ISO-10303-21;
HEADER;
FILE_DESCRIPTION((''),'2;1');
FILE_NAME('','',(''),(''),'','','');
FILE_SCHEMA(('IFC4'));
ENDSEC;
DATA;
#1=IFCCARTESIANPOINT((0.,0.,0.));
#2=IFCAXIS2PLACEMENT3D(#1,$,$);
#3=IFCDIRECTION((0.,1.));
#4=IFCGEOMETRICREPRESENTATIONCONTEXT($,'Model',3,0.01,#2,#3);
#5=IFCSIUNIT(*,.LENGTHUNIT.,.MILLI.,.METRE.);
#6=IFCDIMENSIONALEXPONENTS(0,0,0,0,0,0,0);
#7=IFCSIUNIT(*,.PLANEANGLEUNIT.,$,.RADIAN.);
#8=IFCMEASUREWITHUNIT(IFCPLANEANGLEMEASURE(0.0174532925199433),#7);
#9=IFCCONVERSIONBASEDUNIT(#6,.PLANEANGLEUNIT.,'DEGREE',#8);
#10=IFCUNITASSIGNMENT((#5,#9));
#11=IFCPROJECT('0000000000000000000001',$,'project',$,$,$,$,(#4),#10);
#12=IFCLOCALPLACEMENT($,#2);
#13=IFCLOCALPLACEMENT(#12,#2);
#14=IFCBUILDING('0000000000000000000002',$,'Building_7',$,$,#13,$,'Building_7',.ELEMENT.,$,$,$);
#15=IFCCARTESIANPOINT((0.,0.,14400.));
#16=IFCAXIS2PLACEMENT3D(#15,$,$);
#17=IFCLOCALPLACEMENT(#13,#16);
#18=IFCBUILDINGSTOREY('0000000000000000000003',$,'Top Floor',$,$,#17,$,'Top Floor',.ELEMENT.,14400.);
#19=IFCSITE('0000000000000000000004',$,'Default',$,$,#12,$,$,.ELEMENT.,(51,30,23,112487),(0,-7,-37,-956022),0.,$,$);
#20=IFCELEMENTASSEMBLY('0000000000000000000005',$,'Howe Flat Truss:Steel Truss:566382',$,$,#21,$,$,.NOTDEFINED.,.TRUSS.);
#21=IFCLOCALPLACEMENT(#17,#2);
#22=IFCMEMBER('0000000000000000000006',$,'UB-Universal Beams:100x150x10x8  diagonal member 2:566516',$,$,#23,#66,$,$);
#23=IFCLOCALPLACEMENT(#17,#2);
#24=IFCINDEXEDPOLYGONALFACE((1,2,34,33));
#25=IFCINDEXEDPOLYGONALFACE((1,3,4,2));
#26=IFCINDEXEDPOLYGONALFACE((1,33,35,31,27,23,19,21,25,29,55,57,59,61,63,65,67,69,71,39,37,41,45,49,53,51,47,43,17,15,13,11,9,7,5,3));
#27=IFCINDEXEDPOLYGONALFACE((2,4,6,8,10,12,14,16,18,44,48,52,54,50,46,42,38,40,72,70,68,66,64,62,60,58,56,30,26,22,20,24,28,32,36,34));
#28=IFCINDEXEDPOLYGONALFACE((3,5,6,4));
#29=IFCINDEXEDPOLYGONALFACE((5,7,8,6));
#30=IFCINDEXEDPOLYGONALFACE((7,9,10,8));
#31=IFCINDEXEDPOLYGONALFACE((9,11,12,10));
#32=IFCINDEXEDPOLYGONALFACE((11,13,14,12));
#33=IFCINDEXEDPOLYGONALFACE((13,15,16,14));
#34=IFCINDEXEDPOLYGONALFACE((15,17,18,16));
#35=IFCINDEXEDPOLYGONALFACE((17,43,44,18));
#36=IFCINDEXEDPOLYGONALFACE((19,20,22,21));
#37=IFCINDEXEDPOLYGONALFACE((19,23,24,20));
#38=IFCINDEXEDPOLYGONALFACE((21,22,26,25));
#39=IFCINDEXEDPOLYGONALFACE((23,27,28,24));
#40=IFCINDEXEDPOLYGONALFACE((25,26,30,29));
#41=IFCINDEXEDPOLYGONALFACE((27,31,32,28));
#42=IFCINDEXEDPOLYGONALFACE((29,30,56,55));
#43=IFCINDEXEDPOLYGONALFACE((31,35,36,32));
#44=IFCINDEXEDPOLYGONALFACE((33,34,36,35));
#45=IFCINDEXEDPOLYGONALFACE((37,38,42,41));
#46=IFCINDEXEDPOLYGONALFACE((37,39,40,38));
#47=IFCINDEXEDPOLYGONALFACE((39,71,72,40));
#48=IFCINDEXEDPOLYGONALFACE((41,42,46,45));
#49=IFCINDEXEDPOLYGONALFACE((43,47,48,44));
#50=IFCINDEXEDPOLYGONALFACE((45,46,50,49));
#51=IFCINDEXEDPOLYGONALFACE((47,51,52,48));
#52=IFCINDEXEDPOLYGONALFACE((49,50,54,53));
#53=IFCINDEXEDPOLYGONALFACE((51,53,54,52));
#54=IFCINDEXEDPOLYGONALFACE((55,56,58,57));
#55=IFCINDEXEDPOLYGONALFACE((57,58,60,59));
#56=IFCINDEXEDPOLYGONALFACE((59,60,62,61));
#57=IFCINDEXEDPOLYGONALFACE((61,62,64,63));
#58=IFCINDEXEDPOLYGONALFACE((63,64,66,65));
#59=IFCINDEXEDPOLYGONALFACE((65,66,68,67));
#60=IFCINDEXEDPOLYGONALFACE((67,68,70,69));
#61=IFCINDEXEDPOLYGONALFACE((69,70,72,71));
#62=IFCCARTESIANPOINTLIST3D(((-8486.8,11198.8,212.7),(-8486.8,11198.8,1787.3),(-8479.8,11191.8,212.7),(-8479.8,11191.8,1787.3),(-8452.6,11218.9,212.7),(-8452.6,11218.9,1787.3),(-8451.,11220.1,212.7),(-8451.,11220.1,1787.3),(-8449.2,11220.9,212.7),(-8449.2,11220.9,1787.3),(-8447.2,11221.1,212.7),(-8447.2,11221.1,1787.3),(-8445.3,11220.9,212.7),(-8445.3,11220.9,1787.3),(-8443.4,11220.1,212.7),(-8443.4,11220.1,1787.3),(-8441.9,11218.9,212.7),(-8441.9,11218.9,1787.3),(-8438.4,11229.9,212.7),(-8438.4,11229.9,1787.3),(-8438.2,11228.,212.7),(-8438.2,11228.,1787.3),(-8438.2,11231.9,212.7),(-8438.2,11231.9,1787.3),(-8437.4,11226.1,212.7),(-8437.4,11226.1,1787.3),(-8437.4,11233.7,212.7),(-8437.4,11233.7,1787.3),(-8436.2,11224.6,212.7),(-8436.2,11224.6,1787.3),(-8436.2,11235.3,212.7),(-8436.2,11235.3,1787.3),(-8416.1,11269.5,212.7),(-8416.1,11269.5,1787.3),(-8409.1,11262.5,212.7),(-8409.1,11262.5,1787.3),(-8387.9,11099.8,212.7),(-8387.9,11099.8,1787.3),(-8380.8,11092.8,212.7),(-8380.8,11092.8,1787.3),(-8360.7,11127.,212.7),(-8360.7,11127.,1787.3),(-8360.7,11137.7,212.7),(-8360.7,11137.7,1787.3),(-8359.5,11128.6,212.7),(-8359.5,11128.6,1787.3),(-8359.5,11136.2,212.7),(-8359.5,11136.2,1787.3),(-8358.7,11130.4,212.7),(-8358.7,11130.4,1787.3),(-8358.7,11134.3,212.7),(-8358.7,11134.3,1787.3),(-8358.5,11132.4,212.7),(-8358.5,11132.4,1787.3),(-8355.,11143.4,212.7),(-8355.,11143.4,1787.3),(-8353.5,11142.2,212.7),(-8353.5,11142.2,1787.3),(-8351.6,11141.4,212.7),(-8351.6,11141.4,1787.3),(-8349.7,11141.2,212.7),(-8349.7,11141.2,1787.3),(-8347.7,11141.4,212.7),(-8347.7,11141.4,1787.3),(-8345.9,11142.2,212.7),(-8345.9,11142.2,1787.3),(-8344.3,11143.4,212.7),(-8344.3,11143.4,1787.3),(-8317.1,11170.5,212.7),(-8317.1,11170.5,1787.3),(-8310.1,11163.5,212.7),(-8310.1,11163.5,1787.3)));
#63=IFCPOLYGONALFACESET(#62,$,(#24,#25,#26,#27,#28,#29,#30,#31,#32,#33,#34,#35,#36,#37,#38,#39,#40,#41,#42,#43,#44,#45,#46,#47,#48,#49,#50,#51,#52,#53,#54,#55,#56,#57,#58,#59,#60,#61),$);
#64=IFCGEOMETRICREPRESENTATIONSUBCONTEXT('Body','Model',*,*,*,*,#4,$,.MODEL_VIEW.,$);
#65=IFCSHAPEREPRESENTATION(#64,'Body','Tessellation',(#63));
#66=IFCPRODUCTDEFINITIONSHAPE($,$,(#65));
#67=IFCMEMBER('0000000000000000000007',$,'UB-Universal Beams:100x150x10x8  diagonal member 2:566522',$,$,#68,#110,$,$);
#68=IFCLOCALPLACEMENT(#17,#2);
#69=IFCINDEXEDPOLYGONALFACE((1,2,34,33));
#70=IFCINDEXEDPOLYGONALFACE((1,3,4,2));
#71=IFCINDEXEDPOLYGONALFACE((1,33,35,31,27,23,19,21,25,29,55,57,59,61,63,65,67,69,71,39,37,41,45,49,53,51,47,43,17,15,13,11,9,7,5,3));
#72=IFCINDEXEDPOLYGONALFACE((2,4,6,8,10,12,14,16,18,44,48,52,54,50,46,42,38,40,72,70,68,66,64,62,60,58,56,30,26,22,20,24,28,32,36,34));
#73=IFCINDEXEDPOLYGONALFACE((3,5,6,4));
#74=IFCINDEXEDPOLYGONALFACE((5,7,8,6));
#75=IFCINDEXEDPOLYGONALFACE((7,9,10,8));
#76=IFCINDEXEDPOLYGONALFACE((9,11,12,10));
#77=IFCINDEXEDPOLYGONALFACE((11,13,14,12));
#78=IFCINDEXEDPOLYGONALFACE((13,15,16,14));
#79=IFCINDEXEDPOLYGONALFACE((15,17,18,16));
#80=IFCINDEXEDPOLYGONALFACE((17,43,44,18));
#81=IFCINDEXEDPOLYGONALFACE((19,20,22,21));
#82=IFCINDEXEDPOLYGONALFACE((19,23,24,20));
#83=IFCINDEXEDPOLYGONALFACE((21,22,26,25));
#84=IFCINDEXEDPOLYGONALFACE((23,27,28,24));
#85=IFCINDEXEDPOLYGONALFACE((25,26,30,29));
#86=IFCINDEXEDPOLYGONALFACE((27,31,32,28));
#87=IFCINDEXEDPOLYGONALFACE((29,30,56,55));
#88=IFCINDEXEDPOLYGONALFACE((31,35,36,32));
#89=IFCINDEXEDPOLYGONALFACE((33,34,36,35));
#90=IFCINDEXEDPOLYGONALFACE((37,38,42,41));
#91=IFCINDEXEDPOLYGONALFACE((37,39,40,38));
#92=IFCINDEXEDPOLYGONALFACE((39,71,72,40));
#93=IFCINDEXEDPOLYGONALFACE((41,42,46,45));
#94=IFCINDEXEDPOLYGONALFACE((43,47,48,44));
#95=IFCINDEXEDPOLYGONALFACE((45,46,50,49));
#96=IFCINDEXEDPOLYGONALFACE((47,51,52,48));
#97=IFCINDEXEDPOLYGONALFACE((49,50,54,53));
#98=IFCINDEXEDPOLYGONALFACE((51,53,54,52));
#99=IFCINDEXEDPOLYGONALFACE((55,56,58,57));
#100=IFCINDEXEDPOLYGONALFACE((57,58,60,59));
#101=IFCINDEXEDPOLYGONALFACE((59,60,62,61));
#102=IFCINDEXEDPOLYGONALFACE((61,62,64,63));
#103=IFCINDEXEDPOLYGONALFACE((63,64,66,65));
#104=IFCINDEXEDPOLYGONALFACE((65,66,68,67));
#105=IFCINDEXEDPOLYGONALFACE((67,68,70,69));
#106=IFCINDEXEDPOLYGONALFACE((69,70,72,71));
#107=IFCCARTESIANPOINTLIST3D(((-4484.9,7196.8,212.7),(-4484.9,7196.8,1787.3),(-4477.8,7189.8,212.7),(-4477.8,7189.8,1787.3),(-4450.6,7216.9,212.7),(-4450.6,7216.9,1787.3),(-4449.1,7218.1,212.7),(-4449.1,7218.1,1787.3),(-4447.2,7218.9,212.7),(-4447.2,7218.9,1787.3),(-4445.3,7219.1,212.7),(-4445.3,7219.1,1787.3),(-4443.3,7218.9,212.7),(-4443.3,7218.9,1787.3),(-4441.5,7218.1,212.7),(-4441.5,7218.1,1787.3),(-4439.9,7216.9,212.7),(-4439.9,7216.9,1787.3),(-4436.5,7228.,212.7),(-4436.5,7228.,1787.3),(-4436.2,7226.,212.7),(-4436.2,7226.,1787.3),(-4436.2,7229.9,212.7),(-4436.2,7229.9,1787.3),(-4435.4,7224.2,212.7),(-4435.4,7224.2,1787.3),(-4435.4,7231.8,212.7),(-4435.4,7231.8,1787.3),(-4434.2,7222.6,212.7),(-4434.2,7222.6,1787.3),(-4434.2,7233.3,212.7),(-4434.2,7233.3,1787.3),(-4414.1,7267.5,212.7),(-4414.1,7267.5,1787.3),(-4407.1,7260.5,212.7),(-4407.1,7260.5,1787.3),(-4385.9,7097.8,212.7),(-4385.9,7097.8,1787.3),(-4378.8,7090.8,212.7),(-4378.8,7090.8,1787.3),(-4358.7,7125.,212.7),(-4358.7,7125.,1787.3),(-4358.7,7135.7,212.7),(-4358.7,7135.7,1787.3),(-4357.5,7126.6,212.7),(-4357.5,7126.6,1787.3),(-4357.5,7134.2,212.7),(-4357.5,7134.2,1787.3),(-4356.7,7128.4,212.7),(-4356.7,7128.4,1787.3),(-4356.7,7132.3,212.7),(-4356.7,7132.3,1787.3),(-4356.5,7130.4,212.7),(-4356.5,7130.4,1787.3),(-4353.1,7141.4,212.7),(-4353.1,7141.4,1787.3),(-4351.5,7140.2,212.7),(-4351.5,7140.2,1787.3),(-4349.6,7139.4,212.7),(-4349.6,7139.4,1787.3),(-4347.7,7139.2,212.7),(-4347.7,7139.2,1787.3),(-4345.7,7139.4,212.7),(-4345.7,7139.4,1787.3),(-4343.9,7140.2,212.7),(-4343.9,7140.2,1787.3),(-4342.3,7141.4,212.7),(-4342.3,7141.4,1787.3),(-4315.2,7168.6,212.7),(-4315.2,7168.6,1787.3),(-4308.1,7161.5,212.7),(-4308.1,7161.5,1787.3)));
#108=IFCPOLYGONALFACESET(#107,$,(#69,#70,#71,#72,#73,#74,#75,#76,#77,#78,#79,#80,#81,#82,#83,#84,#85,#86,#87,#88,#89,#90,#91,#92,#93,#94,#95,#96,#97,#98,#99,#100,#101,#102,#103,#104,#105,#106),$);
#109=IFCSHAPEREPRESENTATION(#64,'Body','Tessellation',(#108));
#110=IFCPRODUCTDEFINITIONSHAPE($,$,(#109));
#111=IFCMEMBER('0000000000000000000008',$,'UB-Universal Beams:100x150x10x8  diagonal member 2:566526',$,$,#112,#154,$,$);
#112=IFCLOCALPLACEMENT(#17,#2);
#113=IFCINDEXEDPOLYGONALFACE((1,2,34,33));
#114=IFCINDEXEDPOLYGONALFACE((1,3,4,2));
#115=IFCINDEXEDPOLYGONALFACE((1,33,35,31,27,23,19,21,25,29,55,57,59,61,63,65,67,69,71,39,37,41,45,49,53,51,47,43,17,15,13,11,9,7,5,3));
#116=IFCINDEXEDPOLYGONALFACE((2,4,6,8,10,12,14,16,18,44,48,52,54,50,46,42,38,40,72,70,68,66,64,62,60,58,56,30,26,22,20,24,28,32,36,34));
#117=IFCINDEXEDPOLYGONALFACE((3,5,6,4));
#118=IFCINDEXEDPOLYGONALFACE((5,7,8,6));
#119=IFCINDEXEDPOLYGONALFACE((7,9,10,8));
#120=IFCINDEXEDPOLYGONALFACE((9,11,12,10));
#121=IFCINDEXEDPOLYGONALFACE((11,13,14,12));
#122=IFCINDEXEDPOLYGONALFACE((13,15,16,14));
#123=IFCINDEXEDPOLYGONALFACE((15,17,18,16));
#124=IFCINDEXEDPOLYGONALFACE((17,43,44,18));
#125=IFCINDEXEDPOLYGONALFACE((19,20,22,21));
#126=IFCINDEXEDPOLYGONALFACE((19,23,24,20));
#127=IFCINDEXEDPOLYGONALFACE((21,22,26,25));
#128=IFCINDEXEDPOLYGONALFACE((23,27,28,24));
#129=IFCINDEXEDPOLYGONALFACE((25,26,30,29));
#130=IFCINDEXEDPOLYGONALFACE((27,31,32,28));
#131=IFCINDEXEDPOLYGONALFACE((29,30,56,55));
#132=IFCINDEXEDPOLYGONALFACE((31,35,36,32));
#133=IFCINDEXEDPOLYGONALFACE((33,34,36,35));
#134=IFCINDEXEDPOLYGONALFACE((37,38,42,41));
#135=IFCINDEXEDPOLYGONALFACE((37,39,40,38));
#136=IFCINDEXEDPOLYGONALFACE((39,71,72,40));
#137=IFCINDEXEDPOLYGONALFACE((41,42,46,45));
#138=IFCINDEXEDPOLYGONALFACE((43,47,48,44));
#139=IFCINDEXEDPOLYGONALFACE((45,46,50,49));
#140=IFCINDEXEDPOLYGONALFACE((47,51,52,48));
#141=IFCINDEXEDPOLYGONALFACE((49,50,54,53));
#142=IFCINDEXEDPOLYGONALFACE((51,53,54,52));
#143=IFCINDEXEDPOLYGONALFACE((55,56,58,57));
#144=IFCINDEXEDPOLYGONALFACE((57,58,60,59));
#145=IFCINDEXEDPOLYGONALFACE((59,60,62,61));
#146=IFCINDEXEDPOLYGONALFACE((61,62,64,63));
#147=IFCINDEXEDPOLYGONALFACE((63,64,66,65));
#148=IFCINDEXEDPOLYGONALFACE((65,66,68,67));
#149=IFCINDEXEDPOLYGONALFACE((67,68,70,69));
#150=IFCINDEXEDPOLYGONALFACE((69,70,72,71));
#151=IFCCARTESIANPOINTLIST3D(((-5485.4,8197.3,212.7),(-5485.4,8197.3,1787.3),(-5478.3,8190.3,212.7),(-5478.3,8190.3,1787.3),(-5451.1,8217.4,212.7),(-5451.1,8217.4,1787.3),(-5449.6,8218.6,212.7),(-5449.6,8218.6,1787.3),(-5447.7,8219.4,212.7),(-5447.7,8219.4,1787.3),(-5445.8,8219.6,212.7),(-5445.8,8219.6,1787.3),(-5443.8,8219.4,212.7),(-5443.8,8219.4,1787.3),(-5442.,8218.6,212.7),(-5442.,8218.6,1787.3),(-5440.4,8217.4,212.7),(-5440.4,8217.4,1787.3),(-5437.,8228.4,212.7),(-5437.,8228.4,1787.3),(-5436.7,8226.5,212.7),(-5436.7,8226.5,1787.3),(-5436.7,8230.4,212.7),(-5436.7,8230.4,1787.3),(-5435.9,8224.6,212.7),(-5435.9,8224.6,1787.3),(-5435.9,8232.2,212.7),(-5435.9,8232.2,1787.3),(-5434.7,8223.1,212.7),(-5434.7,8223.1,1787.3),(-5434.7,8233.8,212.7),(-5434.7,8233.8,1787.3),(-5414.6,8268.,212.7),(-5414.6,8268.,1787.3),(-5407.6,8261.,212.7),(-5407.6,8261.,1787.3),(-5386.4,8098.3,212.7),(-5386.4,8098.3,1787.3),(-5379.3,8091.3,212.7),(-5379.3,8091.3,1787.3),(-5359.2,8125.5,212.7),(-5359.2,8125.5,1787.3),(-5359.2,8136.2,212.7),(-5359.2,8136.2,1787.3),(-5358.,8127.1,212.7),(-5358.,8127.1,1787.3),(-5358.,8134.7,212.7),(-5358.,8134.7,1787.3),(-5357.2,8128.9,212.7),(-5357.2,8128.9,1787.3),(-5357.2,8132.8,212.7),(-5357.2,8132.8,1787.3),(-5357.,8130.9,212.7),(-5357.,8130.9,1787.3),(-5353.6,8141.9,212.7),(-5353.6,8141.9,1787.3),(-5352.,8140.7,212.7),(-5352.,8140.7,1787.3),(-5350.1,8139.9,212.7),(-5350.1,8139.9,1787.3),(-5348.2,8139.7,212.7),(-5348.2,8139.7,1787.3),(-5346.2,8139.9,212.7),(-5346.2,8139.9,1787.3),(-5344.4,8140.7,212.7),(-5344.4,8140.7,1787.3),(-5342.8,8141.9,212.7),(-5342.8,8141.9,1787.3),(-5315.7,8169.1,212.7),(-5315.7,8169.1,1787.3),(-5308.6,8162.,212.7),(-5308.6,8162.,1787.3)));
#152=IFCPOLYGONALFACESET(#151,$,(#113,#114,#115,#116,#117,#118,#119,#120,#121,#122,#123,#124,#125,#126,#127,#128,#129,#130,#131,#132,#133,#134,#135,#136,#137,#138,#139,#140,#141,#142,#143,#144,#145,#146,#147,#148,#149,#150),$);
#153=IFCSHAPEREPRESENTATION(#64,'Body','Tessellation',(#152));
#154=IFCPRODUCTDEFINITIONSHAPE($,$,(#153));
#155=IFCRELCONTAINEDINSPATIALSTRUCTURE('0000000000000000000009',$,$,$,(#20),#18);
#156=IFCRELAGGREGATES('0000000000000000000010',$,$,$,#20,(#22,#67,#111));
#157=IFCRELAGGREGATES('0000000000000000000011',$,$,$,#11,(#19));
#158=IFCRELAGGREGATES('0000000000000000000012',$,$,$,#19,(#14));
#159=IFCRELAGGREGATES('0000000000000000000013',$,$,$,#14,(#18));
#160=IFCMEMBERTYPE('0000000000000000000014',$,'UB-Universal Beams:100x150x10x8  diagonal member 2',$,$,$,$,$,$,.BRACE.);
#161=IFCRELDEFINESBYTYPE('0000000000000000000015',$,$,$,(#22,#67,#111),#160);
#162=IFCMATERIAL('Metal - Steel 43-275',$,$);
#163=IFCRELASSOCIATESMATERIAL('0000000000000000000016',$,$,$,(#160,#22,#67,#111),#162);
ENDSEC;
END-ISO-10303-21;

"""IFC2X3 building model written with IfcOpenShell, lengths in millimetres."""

from ifc_helpers import new_model, entity, si_unit, converted_unit, direction, frame, frame_2d, origin, place, context, subcontext, project, spatial, polyline, circle_curve, parameter, trimmed, segment, composite_curve, outline, extrude, source, transform, mapped, material, type_object, type_shapes, element, aggregate, save


model = new_model("IFC2X3")

# Units and contexts
model_context = context("Model", 3, precision=0.01, world=origin(), true_north=direction((0.0, 1.0)))
body_context = subcontext(model_context, "Body", "Model", "MODEL_VIEW")
ifc_project = project(units=[si_unit("LENGTHUNIT", "METRE", prefix="MILLI"), converted_unit("PLANEANGLEUNIT", "DEGREE", entity("IfcPlaneAngleMeasure", 0.0174532925199433), si_unit("PLANEANGLEUNIT", "RADIAN"), dimensions=[0, 0, 0, 0, 0, 0, 0])], contexts=[model_context])

# Site, building, storey
site_placement = place(None, origin())
site = spatial("IfcSite", under=ifc_project, at=site_placement, Name="Default", CompositionType="ELEMENT", RefLatitude=(51, 30, 23, 112487), RefLongitude=(0, -7, -37, -956022), RefElevation=0.0)
building_placement = place(site_placement, origin())
building = spatial("IfcBuilding", under=site, at=building_placement, Name="Building_7", LongName="Building_7", CompositionType="ELEMENT")
storey_placement = place(building_placement, frame((0.0, 0.0, 14400.0)))
storey = spatial("IfcBuildingStorey", under=building, at=storey_placement, Name="Top Floor", LongName="Top Floor", CompositionType="ELEMENT", Elevation=14400.0)

# Shared definitions
ifc_material = material(Name="Metal - Steel 43-275")

# Shared definitions
member_type_1 = type_object("IfcMemberType", Name="UB-Universal Beams:100x150x10x8  diagonal member 2", PredefinedType="BRACE", material=ifc_material)
shared_shape_1 = source(origin(), body_context, "Body", "SweptSolid", [
    extrude(outline(composite_curve([segment(polyline([(-50.0, -65.0), (-50.0, -75.0)]), True, "CONTINUOUS"), segment(polyline([(-50.0, -75.0), (50.0, -75.0)]), True, "CONTINUOUS"), segment(polyline([(50.0, -75.0), (50.0, -65.0)]), True, "CONTINUOUS"), segment(polyline([(50.0, -65.0), (11.6, -65.0)]), True, "CONTINUOUS"), segment(trimmed(circle_curve(frame_2d((11.6, -57.4), x_axis=(1.0, 0.0)), 7.6), [parameter(180.0)], [parameter(270.0)], True, "PARAMETER"), False, "CONTINUOUS"), segment(polyline([(4.0, -57.4), (4.0, 57.4)]), True, "CONTINUOUS"), segment(trimmed(circle_curve(frame_2d((11.6, 57.4), x_axis=(1.0, 0.0)), 7.6), [parameter(90.0)], [parameter(180.0)], True, "PARAMETER"), False, "CONTINUOUS"), segment(polyline([(11.6, 65.0), (50.0, 65.0)]), True, "CONTINUOUS"), segment(polyline([(50.0, 65.0), (50.0, 75.0)]), True, "CONTINUOUS"), segment(polyline([(50.0, 75.0), (-50.0, 75.0)]), True, "CONTINUOUS"), segment(polyline([(-50.0, 75.0), (-50.0, 65.0)]), True, "CONTINUOUS"), segment(polyline([(-50.0, 65.0), (-11.6, 65.0)]), True, "CONTINUOUS"), segment(trimmed(circle_curve(frame_2d((-11.6, 57.4), x_axis=(1.0, 0.0)), 7.6), [parameter(360.0)], [parameter(90.0)], True, "PARAMETER"), False, "CONTINUOUS"), segment(polyline([(-4.0, 57.4), (-4.0, -57.4)]), True, "CONTINUOUS"), segment(trimmed(circle_curve(frame_2d((-11.6, -57.4), x_axis=(1.0, 0.0)), 7.6), [parameter(270.0)], [parameter(360.0)], True, "PARAMETER"), False, "CONTINUOUS"), segment(polyline([(-11.6, -65.0), (-50.0, -65.0)]), True, "CONTINUOUS")], self_intersect=False)), frame((-787.3, 0.0, 0.0), z_axis=(-1.0, 0.0, 0.0), x_axis=(0.0, -1.0, 0.0)), (0.0, 0.0, -1.0), 1574.6),
])
type_shapes(member_type_1, [shared_shape_1])

# Element assembly, members
assembly_1_placement = place(storey_placement, origin())
assembly_1 = element("IfcElementAssembly", 1, at=assembly_1_placement, inside=storey, Name="Howe Flat Truss:Steel Truss:566382", AssemblyPlace="NOTDEFINED", PredefinedType="TRUSS")
member_1_placement = place(assembly_1_placement, frame((-8398.5, 11181.1, 1000.0), z_axis=(-0.707107, 0.707107, 0.0), x_axis=(0.0, 0.0, 1.0)))
member_1 = element("IfcMember", 2, at=member_1_placement, type_object=member_type_1, material=ifc_material, Name="UB-Universal Beams:100x150x10x8  diagonal member 2:566516", context=body_context, shape_type="MappedRepresentation", body=[
    mapped(shared_shape_1, transform((0.0, 0.0, 0.0), scale=1.0)),
])
member_2_placement = place(assembly_1_placement, frame((-4396.5, 7179.2, 1000.0), z_axis=(-0.707107, 0.707107, 0.0), x_axis=(0.0, 0.0, 1.0)))
member_2 = element("IfcMember", 3, at=member_2_placement, type_object=member_type_1, material=ifc_material, Name="UB-Universal Beams:100x150x10x8  diagonal member 2:566522", context=body_context, shape_type="MappedRepresentation", body=[
    mapped(shared_shape_1, transform((0.0, 0.0, 0.0), scale=1.0)),
])
member_3_placement = place(assembly_1_placement, frame((-5397.0, 8179.7, 1000.0), z_axis=(-0.707107, 0.707107, 0.0), x_axis=(0.0, 0.0, 1.0)))
member_3 = element("IfcMember", 4, at=member_3_placement, type_object=member_type_1, material=ifc_material, Name="UB-Universal Beams:100x150x10x8  diagonal member 2:566526", context=body_context, shape_type="MappedRepresentation", body=[
    mapped(shared_shape_1, transform((0.0, 0.0, 0.0), scale=1.0)),
])

aggregate(assembly_1, [member_1, member_2, member_3])

save(model, "model.ifc")
